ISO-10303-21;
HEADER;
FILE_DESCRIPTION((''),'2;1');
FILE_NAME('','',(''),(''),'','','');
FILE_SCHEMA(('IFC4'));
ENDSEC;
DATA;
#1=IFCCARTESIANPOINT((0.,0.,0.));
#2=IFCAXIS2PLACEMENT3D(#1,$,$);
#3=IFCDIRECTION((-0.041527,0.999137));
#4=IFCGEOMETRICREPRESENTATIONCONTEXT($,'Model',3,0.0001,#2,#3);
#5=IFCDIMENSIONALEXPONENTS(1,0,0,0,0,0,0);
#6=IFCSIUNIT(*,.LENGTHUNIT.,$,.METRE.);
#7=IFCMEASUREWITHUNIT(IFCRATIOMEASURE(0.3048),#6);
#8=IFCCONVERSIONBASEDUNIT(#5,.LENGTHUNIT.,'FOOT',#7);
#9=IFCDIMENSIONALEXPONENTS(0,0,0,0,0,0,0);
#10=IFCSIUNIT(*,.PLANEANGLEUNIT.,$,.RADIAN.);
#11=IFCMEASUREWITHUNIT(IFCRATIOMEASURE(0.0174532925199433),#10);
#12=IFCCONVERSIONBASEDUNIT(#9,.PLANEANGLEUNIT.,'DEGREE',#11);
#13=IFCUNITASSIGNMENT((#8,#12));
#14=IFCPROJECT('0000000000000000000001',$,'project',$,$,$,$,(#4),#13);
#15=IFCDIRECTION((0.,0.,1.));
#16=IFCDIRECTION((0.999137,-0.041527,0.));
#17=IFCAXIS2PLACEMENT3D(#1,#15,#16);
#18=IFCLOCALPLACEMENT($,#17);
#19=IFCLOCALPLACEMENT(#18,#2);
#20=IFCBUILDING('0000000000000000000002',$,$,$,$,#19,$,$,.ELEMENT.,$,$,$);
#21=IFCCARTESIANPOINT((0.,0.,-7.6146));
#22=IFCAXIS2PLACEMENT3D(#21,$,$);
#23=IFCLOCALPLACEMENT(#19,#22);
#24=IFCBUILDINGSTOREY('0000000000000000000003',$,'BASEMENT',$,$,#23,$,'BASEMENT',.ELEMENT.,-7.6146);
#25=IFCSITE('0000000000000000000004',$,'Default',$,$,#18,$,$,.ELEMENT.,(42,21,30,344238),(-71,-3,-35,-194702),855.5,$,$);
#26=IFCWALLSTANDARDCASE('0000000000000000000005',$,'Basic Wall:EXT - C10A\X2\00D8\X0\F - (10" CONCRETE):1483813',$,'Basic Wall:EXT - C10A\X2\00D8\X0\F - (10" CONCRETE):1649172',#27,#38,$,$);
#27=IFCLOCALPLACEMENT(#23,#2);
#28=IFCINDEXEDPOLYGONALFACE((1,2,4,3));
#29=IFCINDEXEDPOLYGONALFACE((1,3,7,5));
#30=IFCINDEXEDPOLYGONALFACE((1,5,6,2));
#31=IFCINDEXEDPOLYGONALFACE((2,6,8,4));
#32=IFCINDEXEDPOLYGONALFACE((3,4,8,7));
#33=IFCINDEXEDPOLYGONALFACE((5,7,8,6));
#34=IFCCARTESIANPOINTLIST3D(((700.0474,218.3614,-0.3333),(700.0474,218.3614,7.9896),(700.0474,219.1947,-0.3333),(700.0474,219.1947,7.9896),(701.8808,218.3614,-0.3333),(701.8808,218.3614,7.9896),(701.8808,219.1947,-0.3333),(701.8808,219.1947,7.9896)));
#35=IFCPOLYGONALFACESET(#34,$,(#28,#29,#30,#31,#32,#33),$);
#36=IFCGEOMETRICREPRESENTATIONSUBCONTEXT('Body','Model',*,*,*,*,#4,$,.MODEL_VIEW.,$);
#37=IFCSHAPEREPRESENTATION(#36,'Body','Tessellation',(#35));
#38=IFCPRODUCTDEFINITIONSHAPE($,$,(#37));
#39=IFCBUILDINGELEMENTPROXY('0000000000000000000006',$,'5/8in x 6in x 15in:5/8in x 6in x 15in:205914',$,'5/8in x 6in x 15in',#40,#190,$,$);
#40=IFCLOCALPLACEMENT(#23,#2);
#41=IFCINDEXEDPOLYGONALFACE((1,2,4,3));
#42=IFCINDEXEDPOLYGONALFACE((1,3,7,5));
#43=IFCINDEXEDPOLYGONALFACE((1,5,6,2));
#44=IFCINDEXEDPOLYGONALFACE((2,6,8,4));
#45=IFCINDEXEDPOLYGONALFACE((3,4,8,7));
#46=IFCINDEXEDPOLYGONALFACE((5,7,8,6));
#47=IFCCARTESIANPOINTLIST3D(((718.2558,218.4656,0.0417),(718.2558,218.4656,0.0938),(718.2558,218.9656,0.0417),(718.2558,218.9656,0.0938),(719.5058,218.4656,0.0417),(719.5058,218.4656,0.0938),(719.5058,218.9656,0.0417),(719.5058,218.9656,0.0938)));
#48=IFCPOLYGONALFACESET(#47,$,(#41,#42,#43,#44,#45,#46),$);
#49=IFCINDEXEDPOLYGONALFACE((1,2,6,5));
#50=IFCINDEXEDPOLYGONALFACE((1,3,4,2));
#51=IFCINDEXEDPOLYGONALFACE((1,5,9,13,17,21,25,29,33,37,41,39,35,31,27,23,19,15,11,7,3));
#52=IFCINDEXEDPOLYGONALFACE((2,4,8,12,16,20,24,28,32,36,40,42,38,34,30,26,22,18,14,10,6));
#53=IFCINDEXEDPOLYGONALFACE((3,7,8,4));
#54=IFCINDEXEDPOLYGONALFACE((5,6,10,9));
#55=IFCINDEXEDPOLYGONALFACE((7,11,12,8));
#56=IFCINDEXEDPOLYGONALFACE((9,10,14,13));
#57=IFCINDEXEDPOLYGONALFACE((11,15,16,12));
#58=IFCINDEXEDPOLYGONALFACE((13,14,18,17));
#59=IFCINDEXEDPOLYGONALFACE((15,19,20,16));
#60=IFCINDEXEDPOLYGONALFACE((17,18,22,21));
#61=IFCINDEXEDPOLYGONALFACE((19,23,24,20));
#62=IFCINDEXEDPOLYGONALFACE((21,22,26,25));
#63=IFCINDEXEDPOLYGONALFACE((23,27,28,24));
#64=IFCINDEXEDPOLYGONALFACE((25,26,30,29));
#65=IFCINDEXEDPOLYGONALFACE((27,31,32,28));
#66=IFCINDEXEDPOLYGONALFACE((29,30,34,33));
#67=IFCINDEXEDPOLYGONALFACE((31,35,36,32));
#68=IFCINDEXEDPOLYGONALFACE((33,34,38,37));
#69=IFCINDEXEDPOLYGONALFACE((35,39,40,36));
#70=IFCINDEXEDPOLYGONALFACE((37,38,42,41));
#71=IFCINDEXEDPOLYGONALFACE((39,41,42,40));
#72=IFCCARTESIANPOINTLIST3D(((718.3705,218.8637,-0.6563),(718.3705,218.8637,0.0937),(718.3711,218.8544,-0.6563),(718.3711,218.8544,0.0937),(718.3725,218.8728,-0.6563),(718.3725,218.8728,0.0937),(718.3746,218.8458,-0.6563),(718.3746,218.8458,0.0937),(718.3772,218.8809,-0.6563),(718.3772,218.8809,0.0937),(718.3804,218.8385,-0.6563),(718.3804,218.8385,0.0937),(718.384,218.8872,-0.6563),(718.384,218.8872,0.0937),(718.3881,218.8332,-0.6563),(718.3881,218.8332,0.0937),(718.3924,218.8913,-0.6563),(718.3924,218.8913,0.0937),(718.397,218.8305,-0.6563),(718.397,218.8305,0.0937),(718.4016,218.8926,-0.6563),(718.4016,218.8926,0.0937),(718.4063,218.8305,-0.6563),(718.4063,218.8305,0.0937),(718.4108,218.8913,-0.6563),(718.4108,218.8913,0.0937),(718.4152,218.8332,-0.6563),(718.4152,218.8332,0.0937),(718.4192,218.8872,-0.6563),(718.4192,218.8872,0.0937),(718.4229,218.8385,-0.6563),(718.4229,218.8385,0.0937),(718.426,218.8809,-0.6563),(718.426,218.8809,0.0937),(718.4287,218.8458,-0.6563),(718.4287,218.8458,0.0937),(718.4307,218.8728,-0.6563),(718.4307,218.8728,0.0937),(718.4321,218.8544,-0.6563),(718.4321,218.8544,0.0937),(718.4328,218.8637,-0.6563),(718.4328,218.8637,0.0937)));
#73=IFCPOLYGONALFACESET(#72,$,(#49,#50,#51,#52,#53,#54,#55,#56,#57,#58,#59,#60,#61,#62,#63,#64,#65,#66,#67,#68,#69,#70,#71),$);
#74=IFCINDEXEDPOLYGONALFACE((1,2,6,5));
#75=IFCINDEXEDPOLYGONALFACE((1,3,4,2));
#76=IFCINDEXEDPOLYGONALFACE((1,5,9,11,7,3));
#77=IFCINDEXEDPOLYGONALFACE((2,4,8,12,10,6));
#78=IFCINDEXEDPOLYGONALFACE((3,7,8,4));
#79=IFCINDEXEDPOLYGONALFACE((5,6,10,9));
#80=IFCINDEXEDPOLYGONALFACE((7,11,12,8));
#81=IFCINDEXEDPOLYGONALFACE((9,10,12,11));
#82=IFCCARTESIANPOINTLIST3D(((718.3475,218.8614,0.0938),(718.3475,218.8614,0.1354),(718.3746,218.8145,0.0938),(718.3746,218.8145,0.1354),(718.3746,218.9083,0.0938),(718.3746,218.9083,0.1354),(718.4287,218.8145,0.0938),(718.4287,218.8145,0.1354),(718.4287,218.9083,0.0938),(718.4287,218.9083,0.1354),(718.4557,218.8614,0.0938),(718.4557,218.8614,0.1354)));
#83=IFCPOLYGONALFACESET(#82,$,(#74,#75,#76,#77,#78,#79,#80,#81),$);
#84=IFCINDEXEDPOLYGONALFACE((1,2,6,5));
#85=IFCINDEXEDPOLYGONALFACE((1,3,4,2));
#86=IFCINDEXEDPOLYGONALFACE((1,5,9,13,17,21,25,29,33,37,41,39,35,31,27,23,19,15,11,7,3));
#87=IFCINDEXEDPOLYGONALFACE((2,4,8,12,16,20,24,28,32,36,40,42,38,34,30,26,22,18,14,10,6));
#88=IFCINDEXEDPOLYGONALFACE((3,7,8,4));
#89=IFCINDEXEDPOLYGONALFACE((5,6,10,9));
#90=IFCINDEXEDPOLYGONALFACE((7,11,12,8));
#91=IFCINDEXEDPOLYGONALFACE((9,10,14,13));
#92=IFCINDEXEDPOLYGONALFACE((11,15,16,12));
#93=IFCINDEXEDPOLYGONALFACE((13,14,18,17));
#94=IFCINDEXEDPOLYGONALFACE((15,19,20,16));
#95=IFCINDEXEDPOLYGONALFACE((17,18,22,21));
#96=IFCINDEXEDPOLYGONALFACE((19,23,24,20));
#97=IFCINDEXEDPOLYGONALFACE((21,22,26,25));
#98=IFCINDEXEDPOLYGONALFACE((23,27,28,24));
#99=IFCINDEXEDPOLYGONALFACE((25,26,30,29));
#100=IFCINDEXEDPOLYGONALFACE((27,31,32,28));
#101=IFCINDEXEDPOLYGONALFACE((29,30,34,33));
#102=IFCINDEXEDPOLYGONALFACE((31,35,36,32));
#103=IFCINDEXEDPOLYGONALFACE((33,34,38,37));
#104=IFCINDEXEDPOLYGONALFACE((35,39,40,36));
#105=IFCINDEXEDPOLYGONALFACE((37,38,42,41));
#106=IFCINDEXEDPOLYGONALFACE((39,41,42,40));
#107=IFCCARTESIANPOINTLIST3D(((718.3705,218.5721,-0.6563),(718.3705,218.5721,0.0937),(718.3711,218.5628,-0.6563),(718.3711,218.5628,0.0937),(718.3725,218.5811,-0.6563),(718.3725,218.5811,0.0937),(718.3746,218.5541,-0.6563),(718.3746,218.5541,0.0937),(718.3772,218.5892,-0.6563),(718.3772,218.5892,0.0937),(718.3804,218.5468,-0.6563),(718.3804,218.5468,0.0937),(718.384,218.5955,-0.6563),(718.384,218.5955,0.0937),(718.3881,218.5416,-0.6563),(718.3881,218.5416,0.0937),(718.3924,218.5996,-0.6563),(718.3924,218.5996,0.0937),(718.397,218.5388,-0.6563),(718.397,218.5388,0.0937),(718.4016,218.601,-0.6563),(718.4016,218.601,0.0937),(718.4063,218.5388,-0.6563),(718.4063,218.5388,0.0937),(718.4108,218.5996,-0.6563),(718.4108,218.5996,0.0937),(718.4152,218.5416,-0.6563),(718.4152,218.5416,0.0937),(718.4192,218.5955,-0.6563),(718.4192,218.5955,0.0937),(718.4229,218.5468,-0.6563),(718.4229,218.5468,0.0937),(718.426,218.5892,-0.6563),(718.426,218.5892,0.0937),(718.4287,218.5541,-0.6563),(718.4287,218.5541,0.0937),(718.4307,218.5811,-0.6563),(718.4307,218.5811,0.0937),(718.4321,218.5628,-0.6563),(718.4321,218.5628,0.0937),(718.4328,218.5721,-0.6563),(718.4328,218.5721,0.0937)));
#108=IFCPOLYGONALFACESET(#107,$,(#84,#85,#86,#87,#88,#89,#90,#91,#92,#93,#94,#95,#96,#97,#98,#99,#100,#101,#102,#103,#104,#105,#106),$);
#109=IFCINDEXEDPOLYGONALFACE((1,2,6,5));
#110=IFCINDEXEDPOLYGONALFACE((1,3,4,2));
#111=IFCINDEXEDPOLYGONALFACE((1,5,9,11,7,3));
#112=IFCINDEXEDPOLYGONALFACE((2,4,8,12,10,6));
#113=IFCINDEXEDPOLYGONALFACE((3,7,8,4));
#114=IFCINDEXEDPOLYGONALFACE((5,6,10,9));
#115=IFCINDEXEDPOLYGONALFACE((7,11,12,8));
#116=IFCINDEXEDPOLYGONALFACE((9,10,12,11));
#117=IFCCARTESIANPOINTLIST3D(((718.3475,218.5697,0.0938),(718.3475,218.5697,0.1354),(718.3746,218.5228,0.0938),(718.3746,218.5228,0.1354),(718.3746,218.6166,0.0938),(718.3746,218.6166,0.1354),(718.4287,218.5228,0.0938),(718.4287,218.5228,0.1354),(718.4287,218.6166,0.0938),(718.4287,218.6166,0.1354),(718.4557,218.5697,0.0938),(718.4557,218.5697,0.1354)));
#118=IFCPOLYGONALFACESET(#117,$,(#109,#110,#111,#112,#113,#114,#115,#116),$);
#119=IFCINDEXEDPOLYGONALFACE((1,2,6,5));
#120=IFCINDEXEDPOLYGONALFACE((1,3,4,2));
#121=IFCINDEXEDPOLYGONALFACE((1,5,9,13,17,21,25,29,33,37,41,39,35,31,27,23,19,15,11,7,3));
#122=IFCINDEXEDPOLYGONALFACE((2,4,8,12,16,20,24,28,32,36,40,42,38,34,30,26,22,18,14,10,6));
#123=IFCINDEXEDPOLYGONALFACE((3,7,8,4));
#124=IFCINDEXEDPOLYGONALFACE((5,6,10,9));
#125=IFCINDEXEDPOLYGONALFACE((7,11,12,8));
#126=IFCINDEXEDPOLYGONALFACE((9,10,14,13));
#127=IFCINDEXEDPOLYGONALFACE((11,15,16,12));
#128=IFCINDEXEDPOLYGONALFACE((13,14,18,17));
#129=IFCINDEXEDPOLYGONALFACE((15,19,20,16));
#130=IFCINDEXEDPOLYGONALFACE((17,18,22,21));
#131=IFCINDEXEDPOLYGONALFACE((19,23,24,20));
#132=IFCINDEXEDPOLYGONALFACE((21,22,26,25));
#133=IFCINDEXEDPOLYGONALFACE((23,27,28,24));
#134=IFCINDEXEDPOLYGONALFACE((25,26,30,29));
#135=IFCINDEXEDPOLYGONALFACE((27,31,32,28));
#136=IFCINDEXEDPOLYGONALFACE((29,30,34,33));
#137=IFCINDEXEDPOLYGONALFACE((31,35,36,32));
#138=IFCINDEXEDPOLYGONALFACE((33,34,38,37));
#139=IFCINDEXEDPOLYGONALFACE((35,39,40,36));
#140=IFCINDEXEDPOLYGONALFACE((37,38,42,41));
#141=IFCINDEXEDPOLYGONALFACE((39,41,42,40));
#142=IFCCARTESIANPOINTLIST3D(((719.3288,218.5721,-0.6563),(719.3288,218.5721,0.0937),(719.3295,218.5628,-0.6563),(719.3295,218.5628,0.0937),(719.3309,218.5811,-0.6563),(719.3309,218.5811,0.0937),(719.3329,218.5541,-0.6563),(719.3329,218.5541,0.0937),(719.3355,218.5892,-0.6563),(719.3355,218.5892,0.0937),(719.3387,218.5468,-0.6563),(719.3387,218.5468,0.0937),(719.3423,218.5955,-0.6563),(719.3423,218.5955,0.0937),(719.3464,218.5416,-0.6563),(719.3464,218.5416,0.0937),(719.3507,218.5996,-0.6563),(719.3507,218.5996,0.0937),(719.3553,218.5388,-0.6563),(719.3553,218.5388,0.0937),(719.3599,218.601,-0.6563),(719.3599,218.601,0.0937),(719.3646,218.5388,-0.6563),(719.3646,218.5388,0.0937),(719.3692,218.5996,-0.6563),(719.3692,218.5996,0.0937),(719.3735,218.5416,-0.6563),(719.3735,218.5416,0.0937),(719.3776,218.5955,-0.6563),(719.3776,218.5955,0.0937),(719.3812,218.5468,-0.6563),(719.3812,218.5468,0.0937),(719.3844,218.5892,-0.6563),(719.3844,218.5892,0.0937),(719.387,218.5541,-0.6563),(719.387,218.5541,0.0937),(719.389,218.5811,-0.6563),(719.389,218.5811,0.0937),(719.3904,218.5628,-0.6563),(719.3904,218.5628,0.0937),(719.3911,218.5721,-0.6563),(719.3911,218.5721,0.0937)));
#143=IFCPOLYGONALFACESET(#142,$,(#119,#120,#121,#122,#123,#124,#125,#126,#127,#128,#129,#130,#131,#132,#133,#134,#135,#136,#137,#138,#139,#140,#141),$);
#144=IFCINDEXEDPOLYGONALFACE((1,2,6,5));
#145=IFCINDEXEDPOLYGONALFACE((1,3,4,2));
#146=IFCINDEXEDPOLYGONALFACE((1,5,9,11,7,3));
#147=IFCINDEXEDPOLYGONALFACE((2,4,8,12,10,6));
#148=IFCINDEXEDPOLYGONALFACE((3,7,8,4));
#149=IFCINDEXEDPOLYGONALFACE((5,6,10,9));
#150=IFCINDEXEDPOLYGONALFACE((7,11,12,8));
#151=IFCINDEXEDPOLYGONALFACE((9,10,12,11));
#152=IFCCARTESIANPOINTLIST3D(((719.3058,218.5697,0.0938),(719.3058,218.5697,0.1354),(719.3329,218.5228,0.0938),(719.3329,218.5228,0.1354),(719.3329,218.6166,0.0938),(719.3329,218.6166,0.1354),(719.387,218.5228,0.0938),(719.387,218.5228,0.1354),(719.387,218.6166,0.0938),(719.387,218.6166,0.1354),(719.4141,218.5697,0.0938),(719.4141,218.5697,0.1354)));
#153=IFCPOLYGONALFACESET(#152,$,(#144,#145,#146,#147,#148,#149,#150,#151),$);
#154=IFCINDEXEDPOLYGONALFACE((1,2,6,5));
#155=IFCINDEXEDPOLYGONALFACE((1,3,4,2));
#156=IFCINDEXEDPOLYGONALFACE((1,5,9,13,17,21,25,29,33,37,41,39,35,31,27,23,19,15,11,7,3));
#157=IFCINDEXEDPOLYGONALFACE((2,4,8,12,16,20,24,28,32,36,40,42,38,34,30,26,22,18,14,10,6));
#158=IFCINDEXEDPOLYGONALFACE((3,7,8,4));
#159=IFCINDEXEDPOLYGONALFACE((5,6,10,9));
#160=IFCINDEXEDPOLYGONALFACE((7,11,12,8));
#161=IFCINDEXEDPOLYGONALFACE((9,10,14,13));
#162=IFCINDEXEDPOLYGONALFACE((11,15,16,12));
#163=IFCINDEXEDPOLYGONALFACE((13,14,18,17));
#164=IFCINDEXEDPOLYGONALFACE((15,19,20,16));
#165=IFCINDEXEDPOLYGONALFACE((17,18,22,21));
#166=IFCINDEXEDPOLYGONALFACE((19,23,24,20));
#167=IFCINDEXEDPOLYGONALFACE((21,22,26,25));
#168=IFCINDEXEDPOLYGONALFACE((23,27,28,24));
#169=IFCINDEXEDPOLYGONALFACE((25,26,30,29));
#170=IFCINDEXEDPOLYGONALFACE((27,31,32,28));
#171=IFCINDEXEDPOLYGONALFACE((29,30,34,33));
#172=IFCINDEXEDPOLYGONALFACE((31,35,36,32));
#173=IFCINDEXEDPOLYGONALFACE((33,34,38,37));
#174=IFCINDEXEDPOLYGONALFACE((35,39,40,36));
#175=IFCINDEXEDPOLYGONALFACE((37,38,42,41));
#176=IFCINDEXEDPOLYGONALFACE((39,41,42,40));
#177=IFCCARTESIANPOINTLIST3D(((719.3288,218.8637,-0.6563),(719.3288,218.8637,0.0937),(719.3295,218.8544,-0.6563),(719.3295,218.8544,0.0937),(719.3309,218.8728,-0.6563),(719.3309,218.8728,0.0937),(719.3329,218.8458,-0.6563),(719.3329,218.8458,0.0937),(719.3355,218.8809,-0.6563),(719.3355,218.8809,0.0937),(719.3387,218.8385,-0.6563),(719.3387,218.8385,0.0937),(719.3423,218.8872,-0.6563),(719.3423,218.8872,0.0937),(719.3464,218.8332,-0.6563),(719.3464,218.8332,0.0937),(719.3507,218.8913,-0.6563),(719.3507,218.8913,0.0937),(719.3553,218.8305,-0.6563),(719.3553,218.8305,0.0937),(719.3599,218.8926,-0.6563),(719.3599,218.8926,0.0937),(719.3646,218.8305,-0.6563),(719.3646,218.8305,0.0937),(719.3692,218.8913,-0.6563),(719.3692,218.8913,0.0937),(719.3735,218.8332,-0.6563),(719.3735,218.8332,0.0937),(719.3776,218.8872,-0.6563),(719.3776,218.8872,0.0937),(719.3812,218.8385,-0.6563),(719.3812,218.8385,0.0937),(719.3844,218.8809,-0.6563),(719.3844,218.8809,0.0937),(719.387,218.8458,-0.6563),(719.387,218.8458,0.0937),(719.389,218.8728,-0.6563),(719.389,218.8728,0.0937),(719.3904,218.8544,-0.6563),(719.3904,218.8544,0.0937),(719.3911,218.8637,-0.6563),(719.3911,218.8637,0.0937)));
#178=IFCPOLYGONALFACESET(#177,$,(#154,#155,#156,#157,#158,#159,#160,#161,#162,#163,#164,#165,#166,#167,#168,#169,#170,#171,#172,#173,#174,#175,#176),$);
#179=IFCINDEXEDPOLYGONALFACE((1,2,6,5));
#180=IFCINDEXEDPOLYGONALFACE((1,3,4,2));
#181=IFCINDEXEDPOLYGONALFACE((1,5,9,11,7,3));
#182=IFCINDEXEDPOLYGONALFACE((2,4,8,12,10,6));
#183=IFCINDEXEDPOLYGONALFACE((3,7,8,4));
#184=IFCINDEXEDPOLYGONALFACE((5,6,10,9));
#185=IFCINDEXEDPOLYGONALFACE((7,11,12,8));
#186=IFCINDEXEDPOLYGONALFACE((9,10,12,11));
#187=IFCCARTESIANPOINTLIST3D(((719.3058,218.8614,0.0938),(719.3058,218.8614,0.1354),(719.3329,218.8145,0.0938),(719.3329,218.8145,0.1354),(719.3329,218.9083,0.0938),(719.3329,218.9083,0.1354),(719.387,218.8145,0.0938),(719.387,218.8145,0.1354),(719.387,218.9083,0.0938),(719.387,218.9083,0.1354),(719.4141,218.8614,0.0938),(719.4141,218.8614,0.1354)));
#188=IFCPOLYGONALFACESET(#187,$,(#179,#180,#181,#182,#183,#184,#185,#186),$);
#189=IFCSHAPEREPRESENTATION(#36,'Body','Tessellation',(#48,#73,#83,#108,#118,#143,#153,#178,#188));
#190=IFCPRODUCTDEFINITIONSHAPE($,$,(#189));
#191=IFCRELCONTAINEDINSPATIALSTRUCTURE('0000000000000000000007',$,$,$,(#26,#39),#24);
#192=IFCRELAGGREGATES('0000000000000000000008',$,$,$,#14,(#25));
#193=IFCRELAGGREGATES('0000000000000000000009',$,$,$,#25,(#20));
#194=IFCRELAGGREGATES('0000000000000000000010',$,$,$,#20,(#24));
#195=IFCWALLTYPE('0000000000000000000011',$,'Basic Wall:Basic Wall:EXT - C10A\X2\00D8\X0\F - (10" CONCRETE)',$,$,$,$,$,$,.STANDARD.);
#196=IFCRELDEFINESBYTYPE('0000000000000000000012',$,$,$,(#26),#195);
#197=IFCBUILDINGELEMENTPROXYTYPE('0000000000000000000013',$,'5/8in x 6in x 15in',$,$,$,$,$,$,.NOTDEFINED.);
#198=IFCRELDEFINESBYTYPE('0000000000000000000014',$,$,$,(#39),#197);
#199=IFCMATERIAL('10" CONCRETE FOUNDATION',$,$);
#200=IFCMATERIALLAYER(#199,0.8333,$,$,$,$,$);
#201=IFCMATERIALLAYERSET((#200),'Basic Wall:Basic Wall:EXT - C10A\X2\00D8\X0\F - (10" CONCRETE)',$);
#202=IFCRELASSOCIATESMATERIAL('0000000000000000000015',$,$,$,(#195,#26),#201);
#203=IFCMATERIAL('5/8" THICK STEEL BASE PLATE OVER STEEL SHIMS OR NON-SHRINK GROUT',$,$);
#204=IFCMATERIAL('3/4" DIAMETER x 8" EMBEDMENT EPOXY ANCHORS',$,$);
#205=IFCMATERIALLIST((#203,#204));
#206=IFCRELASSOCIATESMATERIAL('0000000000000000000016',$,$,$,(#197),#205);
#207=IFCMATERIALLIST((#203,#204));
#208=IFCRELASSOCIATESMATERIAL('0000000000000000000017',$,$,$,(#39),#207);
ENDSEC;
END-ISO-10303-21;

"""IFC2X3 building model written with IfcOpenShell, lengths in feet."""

from ifc_helpers import new_model, entity, si_unit, converted_unit, direction, frame, frame_2d, origin, origin_2d_with_axis, place, context, subcontext, project, spatial, polyline, rectangle, circle, outline, extrude, source, transform, mapped, material, material_list, layer, layer_set, layer_usage, type_object, type_shapes, element, save


model = new_model("IFC2X3")

# Units and contexts
model_context = context("Model", 3, precision=0.0001, world=origin(), true_north=direction((-0.041527, 0.999137)))
body_context = subcontext(model_context, "Body", "Model", "MODEL_VIEW")
ifc_project = project(units=[converted_unit("LENGTHUNIT", "FOOT", entity("IfcRatioMeasure", 0.3048), si_unit("LENGTHUNIT", "METRE"), dimensions=[1, 0, 0, 0, 0, 0, 0]), converted_unit("PLANEANGLEUNIT", "DEGREE", entity("IfcRatioMeasure", 0.0174532925199433), si_unit("PLANEANGLEUNIT", "RADIAN"), dimensions=[0, 0, 0, 0, 0, 0, 0])], contexts=[model_context])

# Site, building, storey
site_placement = place(None, frame((0.0, 0.0, 0.0), z_axis=(0.0, 0.0, 1.0), x_axis=(0.999137, -0.041527, 0.0)))
site = spatial("IfcSite", under=ifc_project, at=site_placement, Name="Default", CompositionType="ELEMENT", RefLatitude=(42, 21, 30, 344238), RefLongitude=(-71, -3, -35, -194702), RefElevation=855.5)
building_placement = place(site_placement, origin())
building = spatial("IfcBuilding", under=site, at=building_placement, CompositionType="ELEMENT")
storey_placement = place(building_placement, frame((0.0, 0.0, -7.6146)))
storey = spatial("IfcBuildingStorey", under=building, at=storey_placement, Name="BASEMENT", LongName="BASEMENT", CompositionType="ELEMENT", Elevation=-7.6146)

# Shared definitions
ifc_material_1 = material(Name="10\" CONCRETE FOUNDATION")
ifc_layer_1 = layer(ifc_material_1, 0.8333)
ifc_layer_set_1 = layer_set([ifc_layer_1], Name="Basic Wall:Basic Wall:EXT - C10AØF - (10\" CONCRETE)")
wall_type_1 = type_object("IfcWallType", Name="Basic Wall:Basic Wall:EXT - C10AØF - (10\" CONCRETE)", PredefinedType="STANDARD", material=ifc_layer_set_1)

# Wall
ifc_layer_usage_1 = layer_usage(ifc_layer_set_1, "AXIS2", "NEGATIVE", 0.4167)
wall_1_placement = place(storey_placement, frame((700.0474, 218.7781, -0.3333)))
element("IfcWallStandardCase", 1, at=wall_1_placement, inside=storey, type_object=wall_type_1, material=ifc_layer_usage_1, Name="Basic Wall:EXT - C10AØF - (10\" CONCRETE):1483813", ObjectType="Basic Wall:EXT - C10AØF - (10\" CONCRETE):1649172", context=body_context, shape_type="SweptSolid", body=[
    extrude(rectangle(XDim=1.8333, YDim=0.8333, at=frame_2d((0.9167, 0.0), x_axis=(-1.0, 0.0))), origin(), (0.0, 0.0, 1.0), 8.3229),
])

# Building element proxy
ifc_material_2 = material(Name="5/8\" THICK STEEL BASE PLATE OVER STEEL SHIMS OR NON-SHRINK GROUT")
ifc_material_3 = material(Name="3/4\" DIAMETER x 8\" EMBEDMENT EPOXY ANCHORS")
ifc_material_list_1 = material_list([ifc_material_2, ifc_material_3])
ifc_material_list_2 = material_list([ifc_material_2, ifc_material_3])
building_element_proxy_type_1 = type_object("IfcBuildingElementProxyType", Name="5/8in x 6in x 15in", PredefinedType="NOTDEFINED", material=ifc_material_list_2)
shared_shape_1 = source(origin(), body_context, "Body", "SweptSolid", [
    extrude(rectangle(XDim=1.25, YDim=0.5, at=origin_2d_with_axis()), frame((0.0417, 0.0668, 0.0), z_axis=(0.0, 0.0, 1.0), x_axis=(0.0, -1.0, 0.0)), (0.0, 0.0, 1.0), 0.0521),
    extrude(circle(Radius=0.0312, at=origin_2d_with_axis()), frame((0.1875, 0.546, -0.6979)), (0.0, 0.0, 1.0), 0.75),
    extrude(outline(polyline([(-0.0271, -0.0469), (0.0271, -0.0469), (0.0541, 0.0), (0.0271, 0.0469), (-0.0271, 0.0469), (-0.0541, 0.0), (-0.0271, -0.0469)])), frame((0.1875, 0.546, 0.0521), z_axis=(0.0, 0.0, 1.0), x_axis=(0.866025, -0.5, 0.0)), (0.0, 0.0, 1.0), 0.0417),
    extrude(circle(Radius=0.0312, at=frame_2d((0.0, 0.0), x_axis=(1.0, 0.0))), frame((-0.1042, 0.546, -0.6979)), (0.0, 0.0, 1.0), 0.75),
    extrude(outline(polyline([(-0.0271, -0.0469), (0.0271, -0.0469), (0.0541, 0.0), (0.0271, 0.0469), (-0.0271, 0.0469), (-0.0541, 0.0), (-0.0271, -0.0469)])), frame((-0.1042, 0.546, 0.0521), z_axis=(0.0, 0.0, 1.0), x_axis=(0.866025, -0.5, 0.0)), (0.0, 0.0, 1.0), 0.0417),
    extrude(circle(Radius=0.0312, at=frame_2d((0.0, 0.0), x_axis=(1.0, 0.0))), frame((-0.1042, -0.4124, -0.6979)), (0.0, 0.0, 1.0), 0.75),
    extrude(outline(polyline([(-0.0271, -0.0469), (0.0271, -0.0469), (0.0541, 0.0), (0.0271, 0.0469), (-0.0271, 0.0469), (-0.0541, 0.0), (-0.0271, -0.0469)])), frame((-0.1042, -0.4124, 0.0521), z_axis=(0.0, 0.0, 1.0), x_axis=(0.866025, -0.5, 0.0)), (0.0, 0.0, 1.0), 0.0417),
    extrude(circle(Radius=0.0312, at=frame_2d((0.0, 0.0), x_axis=(1.0, 0.0))), frame((0.1875, -0.4124, -0.6979)), (0.0, 0.0, 1.0), 0.75),
    extrude(outline(polyline([(-0.0271, -0.0469), (0.0271, -0.0469), (0.0541, 0.0), (0.0271, 0.0469), (-0.0271, 0.0469), (-0.0541, 0.0), (-0.0271, -0.0469)])), frame((0.1875, -0.4124, 0.0521), z_axis=(0.0, 0.0, 1.0), x_axis=(0.866025, -0.5, 0.0)), (0.0, 0.0, 1.0), 0.0417),
])
type_shapes(building_element_proxy_type_1, [shared_shape_1])
proxy_1_placement = place(storey_placement, frame((718.9476, 218.6739, 0.0417), z_axis=(0.0, 0.0, 1.0), x_axis=(0.0, 1.0, 0.0)))
element("IfcBuildingElementProxy", 2, at=proxy_1_placement, inside=storey, type_object=building_element_proxy_type_1, material=ifc_material_list_1, Name="5/8in x 6in x 15in:5/8in x 6in x 15in:205914", ObjectType="5/8in x 6in x 15in", context=body_context, shape_type="MappedRepresentation", body=[
    mapped(shared_shape_1, transform((0.0, 0.0, 0.0), scale=1.0)),
])

save(model, "model.ifc")
